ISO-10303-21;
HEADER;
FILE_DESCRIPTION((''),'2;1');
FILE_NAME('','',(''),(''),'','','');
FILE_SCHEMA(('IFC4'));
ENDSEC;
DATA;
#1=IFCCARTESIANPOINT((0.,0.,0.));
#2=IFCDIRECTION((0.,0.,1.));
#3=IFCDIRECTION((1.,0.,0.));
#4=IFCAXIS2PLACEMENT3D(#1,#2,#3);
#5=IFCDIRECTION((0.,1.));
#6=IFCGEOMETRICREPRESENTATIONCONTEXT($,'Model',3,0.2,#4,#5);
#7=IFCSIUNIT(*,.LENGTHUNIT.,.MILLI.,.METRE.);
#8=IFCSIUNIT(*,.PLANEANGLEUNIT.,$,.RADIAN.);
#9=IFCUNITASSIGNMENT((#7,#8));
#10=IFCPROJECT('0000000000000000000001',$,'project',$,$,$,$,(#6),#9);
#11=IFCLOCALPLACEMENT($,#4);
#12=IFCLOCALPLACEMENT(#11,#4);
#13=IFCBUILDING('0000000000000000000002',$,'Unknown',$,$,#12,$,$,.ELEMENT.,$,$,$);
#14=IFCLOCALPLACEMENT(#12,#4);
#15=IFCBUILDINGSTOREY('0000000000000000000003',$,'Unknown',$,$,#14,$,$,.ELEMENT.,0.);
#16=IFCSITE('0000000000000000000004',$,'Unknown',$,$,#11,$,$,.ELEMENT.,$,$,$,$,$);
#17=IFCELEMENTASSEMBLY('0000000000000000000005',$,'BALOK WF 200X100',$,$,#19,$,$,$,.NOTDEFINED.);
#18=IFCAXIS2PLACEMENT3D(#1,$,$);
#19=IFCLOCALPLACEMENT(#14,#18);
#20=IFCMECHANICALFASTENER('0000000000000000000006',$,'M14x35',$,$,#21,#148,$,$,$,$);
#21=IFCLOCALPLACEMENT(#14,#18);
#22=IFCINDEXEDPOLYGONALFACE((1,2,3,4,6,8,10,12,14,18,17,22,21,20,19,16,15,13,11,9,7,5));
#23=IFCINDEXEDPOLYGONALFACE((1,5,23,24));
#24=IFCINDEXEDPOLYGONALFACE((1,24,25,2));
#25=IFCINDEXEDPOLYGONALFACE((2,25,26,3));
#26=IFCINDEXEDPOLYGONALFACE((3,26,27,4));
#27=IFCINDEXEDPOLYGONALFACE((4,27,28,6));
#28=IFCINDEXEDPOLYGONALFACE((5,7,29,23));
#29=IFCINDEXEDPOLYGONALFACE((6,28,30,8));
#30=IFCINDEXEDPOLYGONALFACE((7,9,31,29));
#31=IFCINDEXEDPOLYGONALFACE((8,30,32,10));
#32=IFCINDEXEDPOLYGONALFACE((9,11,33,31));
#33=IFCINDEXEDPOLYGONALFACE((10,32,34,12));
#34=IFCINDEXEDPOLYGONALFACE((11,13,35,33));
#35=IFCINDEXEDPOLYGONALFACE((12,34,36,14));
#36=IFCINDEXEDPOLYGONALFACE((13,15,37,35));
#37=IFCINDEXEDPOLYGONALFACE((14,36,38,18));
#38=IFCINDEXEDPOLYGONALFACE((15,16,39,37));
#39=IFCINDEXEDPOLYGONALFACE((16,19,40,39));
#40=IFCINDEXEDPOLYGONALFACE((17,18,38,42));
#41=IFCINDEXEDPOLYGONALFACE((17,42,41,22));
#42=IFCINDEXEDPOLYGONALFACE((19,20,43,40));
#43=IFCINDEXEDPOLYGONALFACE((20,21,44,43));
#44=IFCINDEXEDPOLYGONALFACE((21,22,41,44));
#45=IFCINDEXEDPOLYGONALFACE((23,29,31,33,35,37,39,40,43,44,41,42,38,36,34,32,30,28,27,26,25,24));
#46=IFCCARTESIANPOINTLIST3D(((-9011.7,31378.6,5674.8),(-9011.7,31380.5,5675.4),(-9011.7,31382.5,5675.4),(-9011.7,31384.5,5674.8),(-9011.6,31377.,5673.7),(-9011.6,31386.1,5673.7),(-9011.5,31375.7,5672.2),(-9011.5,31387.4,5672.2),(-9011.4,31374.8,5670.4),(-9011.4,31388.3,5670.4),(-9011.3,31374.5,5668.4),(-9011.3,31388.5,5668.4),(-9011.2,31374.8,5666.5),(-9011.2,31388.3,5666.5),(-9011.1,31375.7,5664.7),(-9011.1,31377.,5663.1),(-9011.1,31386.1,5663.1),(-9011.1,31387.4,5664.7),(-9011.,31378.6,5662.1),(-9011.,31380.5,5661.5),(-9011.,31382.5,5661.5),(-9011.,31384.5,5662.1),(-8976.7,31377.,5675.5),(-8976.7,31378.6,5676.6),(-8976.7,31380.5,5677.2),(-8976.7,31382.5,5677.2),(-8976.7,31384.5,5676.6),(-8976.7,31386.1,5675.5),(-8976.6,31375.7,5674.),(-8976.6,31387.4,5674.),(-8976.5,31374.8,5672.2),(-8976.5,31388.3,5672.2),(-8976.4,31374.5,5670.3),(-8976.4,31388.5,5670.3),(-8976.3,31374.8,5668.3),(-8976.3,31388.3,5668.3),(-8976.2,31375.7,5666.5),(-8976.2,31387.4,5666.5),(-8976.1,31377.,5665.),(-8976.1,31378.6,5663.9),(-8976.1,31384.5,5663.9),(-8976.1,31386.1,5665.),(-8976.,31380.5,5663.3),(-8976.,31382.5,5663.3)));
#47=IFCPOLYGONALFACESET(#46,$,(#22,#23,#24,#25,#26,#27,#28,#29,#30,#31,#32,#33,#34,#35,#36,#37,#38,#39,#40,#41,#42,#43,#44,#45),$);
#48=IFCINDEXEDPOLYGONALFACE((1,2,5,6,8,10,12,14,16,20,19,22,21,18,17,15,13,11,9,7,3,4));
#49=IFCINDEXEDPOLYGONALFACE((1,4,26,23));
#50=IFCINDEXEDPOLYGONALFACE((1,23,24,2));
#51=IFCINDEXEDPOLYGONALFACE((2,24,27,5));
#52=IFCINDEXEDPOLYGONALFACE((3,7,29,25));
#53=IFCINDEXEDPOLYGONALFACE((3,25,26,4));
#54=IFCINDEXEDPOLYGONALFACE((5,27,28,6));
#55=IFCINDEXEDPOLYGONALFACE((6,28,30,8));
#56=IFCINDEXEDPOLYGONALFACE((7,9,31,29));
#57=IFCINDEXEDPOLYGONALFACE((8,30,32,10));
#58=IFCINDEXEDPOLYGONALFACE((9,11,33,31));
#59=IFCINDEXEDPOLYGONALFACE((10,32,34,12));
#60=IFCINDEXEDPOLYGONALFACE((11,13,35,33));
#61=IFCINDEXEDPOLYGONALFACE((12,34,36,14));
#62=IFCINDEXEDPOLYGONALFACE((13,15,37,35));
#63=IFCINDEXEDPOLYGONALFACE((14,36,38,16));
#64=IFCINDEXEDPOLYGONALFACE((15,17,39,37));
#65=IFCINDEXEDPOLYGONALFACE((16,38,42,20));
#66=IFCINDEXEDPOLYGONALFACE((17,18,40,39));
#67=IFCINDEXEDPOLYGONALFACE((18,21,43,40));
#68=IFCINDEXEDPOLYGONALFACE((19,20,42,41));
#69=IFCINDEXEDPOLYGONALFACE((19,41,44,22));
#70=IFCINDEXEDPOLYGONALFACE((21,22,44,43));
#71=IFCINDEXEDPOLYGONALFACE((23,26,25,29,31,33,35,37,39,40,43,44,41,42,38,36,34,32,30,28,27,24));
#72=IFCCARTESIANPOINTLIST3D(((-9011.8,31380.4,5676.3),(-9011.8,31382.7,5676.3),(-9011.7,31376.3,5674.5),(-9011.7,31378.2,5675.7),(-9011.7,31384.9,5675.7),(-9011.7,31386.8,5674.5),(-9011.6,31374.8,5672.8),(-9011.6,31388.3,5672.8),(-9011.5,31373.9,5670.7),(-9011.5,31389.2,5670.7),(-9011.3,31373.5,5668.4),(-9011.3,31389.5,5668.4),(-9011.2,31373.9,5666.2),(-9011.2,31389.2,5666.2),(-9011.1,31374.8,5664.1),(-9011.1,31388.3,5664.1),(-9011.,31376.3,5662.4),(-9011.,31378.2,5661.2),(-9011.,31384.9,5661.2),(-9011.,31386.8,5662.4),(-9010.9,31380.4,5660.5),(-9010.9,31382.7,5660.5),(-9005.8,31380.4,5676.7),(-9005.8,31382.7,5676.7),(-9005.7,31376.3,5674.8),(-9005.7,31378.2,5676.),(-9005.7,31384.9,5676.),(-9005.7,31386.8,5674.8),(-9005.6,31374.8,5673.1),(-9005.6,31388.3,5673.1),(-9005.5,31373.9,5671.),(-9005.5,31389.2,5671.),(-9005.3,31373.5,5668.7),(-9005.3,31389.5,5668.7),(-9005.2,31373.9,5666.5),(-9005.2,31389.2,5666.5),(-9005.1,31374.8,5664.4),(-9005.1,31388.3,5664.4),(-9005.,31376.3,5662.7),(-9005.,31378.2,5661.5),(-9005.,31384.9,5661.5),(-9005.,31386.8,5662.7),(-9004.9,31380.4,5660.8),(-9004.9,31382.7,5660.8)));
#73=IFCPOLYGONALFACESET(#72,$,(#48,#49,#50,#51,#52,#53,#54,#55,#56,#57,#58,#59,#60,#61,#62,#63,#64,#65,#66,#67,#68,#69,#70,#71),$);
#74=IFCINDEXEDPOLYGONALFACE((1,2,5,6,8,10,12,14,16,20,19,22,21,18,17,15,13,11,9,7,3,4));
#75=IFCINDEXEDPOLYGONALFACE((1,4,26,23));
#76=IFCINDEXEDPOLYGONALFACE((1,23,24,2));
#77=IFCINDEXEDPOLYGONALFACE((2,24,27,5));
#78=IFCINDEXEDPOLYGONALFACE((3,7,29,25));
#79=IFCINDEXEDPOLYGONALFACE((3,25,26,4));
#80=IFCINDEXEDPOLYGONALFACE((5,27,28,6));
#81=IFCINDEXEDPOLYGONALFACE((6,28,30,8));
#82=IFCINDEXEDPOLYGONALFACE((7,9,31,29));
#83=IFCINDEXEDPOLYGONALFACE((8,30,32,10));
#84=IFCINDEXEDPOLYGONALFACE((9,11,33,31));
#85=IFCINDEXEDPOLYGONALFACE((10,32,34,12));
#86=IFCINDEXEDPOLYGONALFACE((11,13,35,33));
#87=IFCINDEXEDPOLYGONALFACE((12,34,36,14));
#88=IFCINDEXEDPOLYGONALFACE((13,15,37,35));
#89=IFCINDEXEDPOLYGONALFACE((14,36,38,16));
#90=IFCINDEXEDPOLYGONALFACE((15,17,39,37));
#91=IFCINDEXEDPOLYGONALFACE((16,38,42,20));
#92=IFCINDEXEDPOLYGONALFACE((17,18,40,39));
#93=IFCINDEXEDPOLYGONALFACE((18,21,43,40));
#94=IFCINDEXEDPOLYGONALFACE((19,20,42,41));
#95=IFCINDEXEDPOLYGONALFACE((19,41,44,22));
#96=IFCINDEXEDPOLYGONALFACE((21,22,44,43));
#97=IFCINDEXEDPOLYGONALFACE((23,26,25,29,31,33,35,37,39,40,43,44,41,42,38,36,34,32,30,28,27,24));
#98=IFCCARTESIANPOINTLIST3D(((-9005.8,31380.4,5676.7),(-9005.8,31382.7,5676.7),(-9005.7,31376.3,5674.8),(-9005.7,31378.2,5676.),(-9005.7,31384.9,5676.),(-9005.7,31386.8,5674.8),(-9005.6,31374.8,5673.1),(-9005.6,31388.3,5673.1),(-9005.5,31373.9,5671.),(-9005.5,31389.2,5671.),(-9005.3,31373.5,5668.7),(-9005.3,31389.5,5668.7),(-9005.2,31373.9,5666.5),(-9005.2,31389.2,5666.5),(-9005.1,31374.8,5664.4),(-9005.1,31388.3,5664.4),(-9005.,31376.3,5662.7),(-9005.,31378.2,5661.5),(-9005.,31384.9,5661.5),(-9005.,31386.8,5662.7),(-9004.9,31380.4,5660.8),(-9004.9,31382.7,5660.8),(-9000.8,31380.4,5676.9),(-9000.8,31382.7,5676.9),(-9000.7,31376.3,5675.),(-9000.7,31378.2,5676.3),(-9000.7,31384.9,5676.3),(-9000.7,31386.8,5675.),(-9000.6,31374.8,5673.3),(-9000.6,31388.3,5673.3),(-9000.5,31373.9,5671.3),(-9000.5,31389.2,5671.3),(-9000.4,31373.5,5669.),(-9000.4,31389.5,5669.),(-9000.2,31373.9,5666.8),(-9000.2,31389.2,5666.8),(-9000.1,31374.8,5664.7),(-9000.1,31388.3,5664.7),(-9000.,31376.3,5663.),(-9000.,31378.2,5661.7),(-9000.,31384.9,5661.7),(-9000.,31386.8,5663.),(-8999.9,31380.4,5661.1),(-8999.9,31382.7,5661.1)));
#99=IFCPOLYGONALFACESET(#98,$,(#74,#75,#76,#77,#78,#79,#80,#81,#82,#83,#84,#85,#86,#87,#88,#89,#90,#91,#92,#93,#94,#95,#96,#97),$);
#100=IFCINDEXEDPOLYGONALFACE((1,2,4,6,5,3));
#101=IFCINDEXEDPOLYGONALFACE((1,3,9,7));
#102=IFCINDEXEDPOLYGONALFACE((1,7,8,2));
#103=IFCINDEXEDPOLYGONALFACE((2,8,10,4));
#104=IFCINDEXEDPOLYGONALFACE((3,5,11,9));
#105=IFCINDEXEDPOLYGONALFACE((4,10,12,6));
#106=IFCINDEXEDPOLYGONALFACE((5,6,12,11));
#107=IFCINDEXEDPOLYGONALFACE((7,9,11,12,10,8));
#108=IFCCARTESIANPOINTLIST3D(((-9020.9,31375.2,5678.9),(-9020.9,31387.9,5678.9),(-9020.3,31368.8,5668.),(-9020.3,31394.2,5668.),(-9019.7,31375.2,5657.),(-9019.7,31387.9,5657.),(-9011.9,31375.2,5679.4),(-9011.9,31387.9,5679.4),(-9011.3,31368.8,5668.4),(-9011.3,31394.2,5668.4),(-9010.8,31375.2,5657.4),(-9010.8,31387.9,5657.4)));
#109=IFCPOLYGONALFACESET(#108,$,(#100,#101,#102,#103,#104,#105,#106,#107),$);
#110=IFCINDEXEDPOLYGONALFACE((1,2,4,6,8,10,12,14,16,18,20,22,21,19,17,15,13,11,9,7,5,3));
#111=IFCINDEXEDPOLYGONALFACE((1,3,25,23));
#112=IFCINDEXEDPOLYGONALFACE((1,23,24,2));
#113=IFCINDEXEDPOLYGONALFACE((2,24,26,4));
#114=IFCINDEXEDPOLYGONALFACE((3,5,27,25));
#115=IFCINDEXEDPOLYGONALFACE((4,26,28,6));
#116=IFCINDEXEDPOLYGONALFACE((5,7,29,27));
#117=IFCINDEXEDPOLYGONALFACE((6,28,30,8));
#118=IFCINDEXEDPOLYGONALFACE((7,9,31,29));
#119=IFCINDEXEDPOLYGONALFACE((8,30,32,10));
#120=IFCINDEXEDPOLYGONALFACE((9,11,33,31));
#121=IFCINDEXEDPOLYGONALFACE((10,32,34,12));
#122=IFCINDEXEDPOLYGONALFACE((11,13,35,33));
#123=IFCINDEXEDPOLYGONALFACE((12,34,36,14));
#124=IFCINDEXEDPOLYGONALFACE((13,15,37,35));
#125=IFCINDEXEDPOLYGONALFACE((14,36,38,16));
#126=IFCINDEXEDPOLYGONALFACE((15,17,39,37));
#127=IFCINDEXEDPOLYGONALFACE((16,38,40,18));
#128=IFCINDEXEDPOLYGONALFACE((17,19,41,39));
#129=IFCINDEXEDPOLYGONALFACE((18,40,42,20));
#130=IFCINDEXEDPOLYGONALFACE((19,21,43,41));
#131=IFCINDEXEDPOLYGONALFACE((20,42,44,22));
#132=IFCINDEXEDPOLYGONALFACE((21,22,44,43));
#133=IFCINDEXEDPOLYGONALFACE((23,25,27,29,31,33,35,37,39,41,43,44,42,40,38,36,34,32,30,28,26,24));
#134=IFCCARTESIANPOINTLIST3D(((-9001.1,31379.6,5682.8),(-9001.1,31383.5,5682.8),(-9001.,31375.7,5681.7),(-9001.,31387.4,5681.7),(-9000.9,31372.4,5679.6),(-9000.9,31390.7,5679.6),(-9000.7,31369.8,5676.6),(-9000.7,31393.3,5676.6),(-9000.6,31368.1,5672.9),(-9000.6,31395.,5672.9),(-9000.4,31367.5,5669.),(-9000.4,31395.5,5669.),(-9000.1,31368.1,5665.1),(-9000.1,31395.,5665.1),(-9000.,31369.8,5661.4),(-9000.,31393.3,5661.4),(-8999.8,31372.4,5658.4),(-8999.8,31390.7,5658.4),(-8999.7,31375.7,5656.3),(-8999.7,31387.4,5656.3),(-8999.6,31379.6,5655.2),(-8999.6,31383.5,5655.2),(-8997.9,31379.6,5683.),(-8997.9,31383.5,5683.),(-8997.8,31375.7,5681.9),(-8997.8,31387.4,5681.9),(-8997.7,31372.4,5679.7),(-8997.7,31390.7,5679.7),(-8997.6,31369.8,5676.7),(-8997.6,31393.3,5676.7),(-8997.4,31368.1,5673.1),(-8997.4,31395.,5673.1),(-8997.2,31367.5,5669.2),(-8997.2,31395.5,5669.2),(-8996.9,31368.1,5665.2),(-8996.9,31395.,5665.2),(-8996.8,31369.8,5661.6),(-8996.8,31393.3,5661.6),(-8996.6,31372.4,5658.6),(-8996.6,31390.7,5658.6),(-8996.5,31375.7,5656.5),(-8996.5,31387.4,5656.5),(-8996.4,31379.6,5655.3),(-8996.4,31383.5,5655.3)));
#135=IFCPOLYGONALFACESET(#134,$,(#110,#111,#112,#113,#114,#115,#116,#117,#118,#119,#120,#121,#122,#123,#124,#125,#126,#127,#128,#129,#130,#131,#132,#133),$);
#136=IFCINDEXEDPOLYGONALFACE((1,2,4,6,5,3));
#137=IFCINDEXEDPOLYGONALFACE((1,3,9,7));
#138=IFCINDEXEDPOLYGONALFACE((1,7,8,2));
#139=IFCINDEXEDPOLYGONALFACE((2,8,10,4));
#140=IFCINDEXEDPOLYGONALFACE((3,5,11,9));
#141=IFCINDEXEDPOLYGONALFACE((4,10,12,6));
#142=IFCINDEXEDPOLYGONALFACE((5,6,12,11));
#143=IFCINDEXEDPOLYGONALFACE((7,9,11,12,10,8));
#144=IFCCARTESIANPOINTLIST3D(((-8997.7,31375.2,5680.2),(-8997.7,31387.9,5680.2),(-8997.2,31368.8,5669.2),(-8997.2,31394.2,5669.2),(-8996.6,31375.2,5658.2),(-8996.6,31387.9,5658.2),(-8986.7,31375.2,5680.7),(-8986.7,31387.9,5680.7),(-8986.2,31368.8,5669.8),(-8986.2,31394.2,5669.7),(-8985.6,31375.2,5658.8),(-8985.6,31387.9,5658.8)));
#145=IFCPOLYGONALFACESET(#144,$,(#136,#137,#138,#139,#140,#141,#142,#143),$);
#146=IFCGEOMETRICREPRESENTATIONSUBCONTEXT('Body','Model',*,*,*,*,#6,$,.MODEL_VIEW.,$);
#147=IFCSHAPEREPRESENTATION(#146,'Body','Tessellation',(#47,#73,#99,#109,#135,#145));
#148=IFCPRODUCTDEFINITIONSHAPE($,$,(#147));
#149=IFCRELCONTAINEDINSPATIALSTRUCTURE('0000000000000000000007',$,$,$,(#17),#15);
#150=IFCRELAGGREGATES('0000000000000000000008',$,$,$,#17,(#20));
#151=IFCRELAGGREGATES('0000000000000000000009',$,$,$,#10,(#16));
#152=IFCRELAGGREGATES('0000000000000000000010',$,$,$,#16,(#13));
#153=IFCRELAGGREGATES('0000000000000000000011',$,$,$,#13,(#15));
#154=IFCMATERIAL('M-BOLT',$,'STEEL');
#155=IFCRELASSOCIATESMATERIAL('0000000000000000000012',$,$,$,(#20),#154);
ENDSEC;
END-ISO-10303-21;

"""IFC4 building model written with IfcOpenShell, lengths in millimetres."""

from ifc_helpers import new_model, si_unit, direction, frame, origin_with_axes, place, context, subcontext, project, spatial, line, arc, indexed_curve, outline, extrude, source, transform, mapped, material, element, aggregate, save


model = new_model("IFC4")

# Units and contexts
model_context = context("Model", 3, precision=0.2, world=origin_with_axes(), true_north=direction((0.0, 1.0)))
body_context = subcontext(model_context, "Body", "Model", "MODEL_VIEW")
ifc_project = project(units=[si_unit("LENGTHUNIT", "METRE", prefix="MILLI"), si_unit("PLANEANGLEUNIT", "RADIAN")], contexts=[model_context])

# Site, building, storey
site_placement = place(None, origin_with_axes())
site = spatial("IfcSite", under=ifc_project, at=site_placement, Name="Unknown", CompositionType="ELEMENT")
building_placement = place(site_placement, origin_with_axes())
building = spatial("IfcBuilding", under=site, at=building_placement, Name="Unknown", CompositionType="ELEMENT")
storey_placement = place(building_placement, origin_with_axes())
storey = spatial("IfcBuildingStorey", under=building, at=storey_placement, Name="Unknown", CompositionType="ELEMENT", Elevation=0.0)

# Element assembly
assembly_1_placement = place(storey_placement, frame((-7044.1, 31466.5, 5721.5), z_axis=(0.0, 1.0, 0.0), x_axis=(-0.99863, 0.0, -0.052336)))
assembly_1 = element("IfcElementAssembly", 1, at=assembly_1_placement, inside=storey, Name="BALOK WF 200X100", PredefinedType="NOTDEFINED")

# Shared definitions
ifc_material_1 = material(Name="M-BOLT", Category="STEEL")

# Shared definitions
shared_shape_1 = source(origin_with_axes(), body_context, "Body", "SweptSolid", [
    extrude(outline(indexed_curve([(7.0, 0.0), (0.0, 7.0), (-7.0, 0.0), (0.0, -7.0)], segments=[arc(1, 2, 3), arc(3, 4, 1)])), frame((0.0, 0.0, 0.0), z_axis=(0.0, 0.0, -1.0), x_axis=(0.0, 1.0, 0.0)), (0.0, 0.0, 1.0), 35.0),
    extrude(outline(indexed_curve([(8.0, 0.0), (0.0, 8.0), (-8.0, 0.0), (0.0, -8.0)], segments=[arc(1, 2, 3), arc(3, 4, 1)])), frame((0.0, 0.0, 0.0), z_axis=(0.0, 0.0, -1.0), x_axis=(0.0, 1.0, 0.0)), (0.0, 0.0, 1.0), 6.0),
    extrude(outline(indexed_curve([(8.0, 0.0), (0.0, 8.0), (-8.0, 0.0), (0.0, -8.0)], segments=[arc(1, 2, 3), arc(3, 4, 1)])), frame((0.0, 0.0, -6.0), z_axis=(0.0, 0.0, -1.0), x_axis=(0.0, 1.0, 0.0)), (0.0, 0.0, 1.0), 5.0),
    extrude(outline(indexed_curve([(12.7, 0.0), (6.4, 11.0), (-6.4, 11.0), (-12.7, 0.0), (-6.4, -11.0), (6.4, -11.0)], segments=[line(1, 2, 3, 4, 5, 6, 1)])), frame((0.0, 0.0, 9.0), z_axis=(0.0, 0.0, -1.0), x_axis=(0.0, 1.0, 0.0)), (0.0, 0.0, 1.0), 9.0),
    extrude(outline(indexed_curve([(14.0, 0.0), (0.0, 14.0), (-14.0, 0.0), (0.0, -14.0)], segments=[arc(1, 2, 3), arc(3, 4, 1)])), frame((0.0, 0.0, -11.0), z_axis=(0.0, 0.0, -1.0), x_axis=(0.0, 1.0, 0.0)), (0.0, 0.0, 1.0), 3.2),
    extrude(outline(indexed_curve([(12.7, 0.0), (6.4, 11.0), (-6.4, 11.0), (-12.7, 0.0), (-6.4, -11.0), (6.4, -11.0)], segments=[line(1, 2, 3, 4, 5, 6, 1)])), frame((0.0, 0.0, -14.2), z_axis=(0.0, 0.0, -1.0), x_axis=(0.0, 1.0, 0.0)), (0.0, 0.0, 1.0), 11.0),
])

# Mechanical fastener
mechanical_fastener_1_placement = place(assembly_1_placement, frame((1967.3, 50.0, -85.0), z_axis=(1.0, 0.0, -0.000006), x_axis=(0.0, -1.0, 0.0)))
mechanical_fastener_1 = element("IfcMechanicalFastener", 2, at=mechanical_fastener_1_placement, material=ifc_material_1, Name="M14x35", context=body_context, shape_type="MappedRepresentation", body=[
    mapped(shared_shape_1, transform((0.0, 0.0, 0.0))),
])
aggregate(assembly_1, [mechanical_fastener_1])

save(model, "model.ifc")
